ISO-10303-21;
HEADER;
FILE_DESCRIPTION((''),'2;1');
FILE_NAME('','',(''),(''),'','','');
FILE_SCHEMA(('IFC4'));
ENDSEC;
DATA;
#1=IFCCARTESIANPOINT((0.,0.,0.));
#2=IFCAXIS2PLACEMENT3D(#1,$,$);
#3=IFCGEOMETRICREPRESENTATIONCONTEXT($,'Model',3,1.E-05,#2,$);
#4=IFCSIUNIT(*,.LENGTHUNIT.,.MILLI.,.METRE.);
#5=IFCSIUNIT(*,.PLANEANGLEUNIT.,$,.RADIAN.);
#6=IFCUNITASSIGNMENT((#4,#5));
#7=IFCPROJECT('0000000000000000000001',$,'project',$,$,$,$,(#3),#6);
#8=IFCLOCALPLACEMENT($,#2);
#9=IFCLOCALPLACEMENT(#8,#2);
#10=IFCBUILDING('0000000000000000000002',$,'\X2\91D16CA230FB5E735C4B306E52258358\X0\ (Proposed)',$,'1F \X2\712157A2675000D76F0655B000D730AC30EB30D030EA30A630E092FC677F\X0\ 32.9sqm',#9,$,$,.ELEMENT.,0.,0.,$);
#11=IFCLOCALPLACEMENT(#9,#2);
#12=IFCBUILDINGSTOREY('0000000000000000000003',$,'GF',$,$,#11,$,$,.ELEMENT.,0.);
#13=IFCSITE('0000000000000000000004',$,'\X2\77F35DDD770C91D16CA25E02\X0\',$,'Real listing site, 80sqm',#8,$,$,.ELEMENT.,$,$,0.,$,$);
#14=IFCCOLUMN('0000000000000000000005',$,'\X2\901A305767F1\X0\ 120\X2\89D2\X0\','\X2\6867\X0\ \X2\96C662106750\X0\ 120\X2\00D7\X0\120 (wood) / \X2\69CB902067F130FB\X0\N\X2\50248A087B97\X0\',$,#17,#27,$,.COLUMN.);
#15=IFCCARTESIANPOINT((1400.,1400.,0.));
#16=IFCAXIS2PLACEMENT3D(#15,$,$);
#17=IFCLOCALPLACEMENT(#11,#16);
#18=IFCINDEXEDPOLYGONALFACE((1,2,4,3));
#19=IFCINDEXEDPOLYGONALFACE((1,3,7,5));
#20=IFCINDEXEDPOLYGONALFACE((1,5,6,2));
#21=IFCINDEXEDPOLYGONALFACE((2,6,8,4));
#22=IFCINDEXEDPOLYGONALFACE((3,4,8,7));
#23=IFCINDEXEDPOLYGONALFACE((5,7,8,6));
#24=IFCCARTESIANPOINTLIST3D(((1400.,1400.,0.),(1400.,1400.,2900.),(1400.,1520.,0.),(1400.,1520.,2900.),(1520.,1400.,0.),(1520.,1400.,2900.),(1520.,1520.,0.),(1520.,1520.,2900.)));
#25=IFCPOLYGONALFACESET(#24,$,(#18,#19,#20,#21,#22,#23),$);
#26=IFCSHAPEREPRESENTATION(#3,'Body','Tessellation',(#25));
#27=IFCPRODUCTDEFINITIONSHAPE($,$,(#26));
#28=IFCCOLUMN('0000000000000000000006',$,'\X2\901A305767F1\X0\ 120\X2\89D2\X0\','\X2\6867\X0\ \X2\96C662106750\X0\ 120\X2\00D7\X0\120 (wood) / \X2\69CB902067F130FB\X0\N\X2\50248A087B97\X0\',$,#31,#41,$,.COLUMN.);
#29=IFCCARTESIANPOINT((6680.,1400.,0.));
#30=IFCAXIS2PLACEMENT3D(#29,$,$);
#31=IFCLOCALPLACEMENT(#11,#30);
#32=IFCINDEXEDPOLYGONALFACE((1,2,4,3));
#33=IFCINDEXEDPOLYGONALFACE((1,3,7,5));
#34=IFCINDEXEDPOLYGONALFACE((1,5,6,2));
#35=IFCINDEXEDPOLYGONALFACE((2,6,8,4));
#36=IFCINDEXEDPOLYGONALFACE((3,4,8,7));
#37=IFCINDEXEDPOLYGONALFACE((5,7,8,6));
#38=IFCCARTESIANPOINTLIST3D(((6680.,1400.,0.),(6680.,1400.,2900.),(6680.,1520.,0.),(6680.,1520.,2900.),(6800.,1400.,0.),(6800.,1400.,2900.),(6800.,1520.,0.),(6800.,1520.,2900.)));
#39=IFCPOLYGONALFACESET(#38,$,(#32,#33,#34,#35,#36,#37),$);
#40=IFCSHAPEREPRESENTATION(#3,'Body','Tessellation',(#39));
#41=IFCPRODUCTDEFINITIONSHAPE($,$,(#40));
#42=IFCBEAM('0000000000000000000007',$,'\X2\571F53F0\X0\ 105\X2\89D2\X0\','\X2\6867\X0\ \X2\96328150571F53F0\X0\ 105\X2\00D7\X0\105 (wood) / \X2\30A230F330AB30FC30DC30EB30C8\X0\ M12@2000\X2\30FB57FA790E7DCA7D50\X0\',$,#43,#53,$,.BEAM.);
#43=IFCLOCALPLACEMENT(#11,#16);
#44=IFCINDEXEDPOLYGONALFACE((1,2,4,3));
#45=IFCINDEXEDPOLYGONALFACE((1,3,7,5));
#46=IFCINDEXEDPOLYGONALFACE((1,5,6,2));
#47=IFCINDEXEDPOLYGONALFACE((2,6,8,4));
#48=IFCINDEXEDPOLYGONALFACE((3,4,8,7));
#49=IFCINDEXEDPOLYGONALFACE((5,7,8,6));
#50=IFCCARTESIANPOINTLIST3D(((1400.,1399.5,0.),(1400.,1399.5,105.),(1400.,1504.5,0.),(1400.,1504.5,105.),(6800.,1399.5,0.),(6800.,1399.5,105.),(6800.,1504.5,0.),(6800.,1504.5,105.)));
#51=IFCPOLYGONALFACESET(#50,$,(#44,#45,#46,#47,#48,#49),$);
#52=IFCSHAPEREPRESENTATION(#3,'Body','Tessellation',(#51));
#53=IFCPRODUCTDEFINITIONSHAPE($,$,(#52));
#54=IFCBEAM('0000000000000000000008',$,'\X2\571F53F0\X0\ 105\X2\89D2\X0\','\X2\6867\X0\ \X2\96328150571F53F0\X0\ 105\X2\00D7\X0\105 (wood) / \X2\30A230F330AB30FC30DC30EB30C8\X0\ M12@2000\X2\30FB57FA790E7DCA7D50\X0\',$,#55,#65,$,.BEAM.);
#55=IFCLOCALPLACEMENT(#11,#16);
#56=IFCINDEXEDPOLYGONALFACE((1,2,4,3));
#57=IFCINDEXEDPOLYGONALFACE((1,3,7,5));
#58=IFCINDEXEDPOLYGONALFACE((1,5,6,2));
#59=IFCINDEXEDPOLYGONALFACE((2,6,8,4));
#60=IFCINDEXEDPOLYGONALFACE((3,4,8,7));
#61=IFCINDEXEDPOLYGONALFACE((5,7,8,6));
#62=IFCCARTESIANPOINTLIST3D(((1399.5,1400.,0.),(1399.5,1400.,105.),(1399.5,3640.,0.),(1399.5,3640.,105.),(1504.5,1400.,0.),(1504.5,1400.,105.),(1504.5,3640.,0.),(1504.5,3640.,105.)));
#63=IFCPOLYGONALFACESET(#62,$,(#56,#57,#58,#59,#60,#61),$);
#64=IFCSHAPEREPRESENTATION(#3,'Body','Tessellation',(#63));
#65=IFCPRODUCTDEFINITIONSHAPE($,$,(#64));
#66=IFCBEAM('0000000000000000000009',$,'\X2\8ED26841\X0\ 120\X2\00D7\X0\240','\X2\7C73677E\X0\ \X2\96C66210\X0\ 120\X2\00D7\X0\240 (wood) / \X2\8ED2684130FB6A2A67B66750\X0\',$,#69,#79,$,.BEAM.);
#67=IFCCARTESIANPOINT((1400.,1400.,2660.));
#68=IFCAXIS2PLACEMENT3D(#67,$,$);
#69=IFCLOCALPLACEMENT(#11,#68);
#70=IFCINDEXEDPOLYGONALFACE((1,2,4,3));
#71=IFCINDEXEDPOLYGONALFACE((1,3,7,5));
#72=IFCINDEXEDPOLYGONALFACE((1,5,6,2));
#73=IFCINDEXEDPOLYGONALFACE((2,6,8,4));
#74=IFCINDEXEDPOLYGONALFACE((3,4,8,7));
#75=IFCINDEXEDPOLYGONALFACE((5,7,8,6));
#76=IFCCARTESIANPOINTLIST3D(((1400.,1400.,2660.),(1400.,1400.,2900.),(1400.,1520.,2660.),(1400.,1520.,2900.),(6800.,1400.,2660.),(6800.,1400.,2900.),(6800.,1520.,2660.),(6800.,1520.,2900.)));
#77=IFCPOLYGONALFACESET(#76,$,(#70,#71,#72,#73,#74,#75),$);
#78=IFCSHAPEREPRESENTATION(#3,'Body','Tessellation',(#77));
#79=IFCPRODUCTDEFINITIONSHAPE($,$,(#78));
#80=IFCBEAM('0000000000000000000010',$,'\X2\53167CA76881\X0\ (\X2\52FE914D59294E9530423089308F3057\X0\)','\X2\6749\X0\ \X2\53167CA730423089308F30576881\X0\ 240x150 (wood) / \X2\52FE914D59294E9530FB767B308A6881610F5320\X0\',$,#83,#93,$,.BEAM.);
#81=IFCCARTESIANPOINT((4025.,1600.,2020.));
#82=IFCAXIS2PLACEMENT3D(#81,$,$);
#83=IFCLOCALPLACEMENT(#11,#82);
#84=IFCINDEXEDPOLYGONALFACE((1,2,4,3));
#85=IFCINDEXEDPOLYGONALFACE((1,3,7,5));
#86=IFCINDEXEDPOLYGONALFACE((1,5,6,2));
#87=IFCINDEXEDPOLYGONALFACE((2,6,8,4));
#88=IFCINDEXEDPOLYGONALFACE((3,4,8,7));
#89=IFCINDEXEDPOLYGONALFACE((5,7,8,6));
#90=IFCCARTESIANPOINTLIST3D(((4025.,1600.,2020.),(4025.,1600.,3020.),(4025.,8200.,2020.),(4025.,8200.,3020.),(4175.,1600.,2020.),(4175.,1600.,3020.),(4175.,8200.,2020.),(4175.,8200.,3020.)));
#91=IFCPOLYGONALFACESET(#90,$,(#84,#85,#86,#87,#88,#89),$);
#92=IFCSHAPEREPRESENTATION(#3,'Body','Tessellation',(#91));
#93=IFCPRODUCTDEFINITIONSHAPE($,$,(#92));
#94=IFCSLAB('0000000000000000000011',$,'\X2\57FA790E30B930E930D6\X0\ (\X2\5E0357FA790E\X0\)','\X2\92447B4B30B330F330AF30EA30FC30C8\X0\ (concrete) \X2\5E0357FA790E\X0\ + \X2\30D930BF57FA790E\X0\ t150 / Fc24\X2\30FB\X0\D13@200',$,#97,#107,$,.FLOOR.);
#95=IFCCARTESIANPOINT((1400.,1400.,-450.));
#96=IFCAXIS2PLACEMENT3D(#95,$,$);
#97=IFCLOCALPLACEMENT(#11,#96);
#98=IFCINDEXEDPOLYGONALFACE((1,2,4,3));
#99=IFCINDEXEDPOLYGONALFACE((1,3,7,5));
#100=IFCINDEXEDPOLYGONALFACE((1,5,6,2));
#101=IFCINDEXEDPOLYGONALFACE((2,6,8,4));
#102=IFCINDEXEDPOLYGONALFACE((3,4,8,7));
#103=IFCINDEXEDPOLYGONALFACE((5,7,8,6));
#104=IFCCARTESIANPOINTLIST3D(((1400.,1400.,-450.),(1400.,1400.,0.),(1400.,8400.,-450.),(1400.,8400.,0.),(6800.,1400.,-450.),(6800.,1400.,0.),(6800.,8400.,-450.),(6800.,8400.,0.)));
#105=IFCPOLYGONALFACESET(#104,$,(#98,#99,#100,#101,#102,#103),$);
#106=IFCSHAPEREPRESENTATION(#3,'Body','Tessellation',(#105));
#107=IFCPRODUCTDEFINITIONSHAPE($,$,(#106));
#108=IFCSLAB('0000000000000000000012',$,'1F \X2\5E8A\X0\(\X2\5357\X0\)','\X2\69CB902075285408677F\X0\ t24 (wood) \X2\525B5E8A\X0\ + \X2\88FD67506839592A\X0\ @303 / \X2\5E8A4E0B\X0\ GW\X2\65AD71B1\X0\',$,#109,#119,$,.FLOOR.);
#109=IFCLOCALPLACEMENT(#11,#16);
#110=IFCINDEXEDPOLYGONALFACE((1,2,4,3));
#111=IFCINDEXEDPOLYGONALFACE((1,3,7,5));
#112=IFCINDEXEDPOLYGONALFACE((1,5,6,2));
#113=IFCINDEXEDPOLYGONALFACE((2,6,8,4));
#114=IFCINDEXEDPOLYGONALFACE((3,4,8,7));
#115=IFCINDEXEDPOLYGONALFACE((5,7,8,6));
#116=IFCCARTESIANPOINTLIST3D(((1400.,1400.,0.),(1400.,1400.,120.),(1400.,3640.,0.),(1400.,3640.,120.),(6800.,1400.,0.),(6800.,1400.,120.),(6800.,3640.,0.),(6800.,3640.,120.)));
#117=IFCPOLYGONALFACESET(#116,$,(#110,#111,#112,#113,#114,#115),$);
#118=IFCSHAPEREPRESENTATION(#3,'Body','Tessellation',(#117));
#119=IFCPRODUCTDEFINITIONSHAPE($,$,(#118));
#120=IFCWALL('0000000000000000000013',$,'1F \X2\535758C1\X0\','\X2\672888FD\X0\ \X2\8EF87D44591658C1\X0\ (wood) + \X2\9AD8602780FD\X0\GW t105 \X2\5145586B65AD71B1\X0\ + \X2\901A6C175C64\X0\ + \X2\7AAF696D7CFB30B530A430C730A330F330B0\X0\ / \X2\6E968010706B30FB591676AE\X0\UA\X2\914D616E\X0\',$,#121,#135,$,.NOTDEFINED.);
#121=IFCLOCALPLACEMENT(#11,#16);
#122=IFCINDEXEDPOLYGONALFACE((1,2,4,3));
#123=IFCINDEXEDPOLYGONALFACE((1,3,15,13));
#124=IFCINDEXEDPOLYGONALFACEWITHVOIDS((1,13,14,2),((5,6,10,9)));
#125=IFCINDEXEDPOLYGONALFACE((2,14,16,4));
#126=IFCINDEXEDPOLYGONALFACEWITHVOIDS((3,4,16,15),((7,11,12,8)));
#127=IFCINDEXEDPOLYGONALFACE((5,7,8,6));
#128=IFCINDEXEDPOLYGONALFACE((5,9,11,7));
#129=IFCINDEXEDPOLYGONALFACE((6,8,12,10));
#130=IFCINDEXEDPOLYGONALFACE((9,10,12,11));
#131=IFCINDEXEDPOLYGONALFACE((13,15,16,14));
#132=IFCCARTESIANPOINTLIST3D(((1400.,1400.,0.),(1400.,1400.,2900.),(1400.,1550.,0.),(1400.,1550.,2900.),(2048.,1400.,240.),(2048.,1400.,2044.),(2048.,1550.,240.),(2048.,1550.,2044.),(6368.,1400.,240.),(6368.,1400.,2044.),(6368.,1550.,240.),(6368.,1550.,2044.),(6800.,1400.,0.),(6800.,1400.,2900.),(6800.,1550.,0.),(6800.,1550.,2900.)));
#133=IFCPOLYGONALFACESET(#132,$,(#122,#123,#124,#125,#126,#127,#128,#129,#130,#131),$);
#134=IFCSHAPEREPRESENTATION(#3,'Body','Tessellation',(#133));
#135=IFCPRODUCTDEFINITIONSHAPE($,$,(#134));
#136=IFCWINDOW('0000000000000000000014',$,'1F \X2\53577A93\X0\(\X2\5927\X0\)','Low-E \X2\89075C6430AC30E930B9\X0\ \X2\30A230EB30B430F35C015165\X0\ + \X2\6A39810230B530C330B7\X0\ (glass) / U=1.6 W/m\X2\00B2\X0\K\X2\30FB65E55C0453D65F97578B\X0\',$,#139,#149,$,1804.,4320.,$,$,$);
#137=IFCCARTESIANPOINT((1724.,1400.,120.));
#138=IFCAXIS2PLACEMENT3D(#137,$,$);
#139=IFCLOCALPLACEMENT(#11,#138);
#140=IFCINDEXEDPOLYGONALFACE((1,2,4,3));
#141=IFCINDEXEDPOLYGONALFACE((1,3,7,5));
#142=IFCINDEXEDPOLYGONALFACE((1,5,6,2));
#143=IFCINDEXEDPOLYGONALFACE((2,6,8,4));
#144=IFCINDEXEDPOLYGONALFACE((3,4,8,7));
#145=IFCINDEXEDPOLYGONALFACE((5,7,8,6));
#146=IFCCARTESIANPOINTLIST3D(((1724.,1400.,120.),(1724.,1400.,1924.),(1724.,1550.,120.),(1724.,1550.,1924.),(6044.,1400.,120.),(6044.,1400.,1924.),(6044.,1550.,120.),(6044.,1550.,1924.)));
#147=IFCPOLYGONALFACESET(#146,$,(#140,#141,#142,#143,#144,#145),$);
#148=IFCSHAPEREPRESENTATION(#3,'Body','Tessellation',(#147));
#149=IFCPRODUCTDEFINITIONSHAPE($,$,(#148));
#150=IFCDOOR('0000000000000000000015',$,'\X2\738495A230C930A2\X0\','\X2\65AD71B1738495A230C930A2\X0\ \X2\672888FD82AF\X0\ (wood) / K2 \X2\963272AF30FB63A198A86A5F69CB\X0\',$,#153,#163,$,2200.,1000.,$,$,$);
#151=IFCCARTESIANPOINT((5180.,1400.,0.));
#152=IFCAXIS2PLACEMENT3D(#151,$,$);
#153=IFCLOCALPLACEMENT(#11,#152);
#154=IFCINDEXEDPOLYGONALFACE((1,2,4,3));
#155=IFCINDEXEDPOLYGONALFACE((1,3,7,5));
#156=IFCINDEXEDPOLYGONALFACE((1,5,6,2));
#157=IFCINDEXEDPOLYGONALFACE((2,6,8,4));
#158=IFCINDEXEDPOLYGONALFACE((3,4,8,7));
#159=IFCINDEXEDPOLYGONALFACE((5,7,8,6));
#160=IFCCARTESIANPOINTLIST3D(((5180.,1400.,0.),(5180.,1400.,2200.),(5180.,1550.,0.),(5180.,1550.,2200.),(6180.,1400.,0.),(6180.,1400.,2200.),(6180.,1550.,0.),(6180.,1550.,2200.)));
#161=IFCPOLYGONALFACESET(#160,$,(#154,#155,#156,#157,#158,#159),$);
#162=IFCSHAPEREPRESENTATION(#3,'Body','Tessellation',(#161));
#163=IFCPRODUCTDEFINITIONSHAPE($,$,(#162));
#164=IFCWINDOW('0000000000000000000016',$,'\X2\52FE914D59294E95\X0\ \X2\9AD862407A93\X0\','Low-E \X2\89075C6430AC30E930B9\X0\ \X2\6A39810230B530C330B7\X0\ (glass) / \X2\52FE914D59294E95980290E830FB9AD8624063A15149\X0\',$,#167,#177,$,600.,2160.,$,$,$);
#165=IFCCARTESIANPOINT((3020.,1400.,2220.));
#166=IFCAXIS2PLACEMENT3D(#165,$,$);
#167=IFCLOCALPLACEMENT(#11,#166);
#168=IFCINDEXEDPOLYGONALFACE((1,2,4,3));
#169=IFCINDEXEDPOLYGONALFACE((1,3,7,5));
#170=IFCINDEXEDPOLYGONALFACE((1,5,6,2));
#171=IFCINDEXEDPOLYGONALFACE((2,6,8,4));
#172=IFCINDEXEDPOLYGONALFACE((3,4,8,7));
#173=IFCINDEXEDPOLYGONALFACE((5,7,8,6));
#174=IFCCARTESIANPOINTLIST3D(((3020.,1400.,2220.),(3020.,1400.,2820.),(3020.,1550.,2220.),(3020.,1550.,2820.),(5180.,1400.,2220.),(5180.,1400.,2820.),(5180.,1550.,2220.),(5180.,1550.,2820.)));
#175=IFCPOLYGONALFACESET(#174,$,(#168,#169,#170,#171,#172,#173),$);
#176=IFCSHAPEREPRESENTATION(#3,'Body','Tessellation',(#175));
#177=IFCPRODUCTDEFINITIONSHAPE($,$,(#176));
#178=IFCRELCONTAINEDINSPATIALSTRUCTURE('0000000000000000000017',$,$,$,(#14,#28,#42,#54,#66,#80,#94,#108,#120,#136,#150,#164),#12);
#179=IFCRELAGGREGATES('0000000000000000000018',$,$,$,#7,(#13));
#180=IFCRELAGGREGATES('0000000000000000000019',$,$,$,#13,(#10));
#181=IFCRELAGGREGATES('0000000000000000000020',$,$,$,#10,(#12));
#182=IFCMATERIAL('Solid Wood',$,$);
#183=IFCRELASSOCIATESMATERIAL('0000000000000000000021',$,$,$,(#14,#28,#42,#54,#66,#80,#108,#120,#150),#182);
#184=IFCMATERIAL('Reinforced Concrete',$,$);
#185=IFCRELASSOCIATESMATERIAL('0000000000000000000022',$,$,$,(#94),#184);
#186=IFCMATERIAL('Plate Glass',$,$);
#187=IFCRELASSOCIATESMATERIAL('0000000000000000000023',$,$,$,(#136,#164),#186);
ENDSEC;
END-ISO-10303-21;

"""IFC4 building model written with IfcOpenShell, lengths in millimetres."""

from ifc_helpers import new_model, si_unit, frame, frame_2d, origin, place, context, project, spatial, rectangle, extrude, material, element, fill, save


model = new_model("IFC4")

# Units and contexts
model_context = context("Model", 3, precision=1e-05, world=origin())
ifc_project = project(units=[si_unit("LENGTHUNIT", "METRE", prefix="MILLI"), si_unit("PLANEANGLEUNIT", "RADIAN")], contexts=[model_context])

# Site, building, storey
site_placement = place(None, origin())
site = spatial("IfcSite", under=ifc_project, at=site_placement, Name="石川県金沢市", ObjectType="Real listing site, 80sqm", CompositionType="ELEMENT", RefElevation=0.0)
building_placement = place(site_placement, origin())
building = spatial("IfcBuilding", under=site, at=building_placement, Name="金沢・平屋の別荘 (Proposed)", ObjectType="1F 無垢材×漆喰×ガルバリウム鋼板 32.9sqm", CompositionType="ELEMENT", ElevationOfRefHeight=0.0, ElevationOfTerrain=0.0)
storey_placement = place(building_placement, origin())
storey = spatial("IfcBuildingStorey", under=building, at=storey_placement, Name="GF", CompositionType="ELEMENT", Elevation=0.0)

# Columns
ifc_material_1 = material(Name="Solid Wood")
column_1_placement = place(storey_placement, frame((1400.0, 1400.0, 0.0)))
element("IfcColumn", 1, at=column_1_placement, inside=storey, material=ifc_material_1, Name="通し柱 120角", Description="桧 集成材 120×120 (wood) / 構造柱・N値計算", PredefinedType="COLUMN", context=model_context, shape_type="SweptSolid", body=[
    extrude(rectangle(XDim=120.0, YDim=120.0, at=frame_2d((60.0, 60.0))), frame((1400.0, 1400.0, 0.0)), (0.0, 0.0, 1.0), 2900.0),
])
column_2_placement = place(storey_placement, frame((6680.0, 1400.0, 0.0)))
element("IfcColumn", 2, at=column_2_placement, inside=storey, material=ifc_material_1, Name="通し柱 120角", Description="桧 集成材 120×120 (wood) / 構造柱・N値計算", PredefinedType="COLUMN", context=model_context, shape_type="SweptSolid", body=[
    extrude(rectangle(XDim=120.0, YDim=120.0, at=frame_2d((60.0, 60.0))), frame((6680.0, 1400.0, 0.0)), (0.0, 0.0, 1.0), 2900.0),
])

# Beams
beam_1_placement = place(storey_placement, frame((1400.0, 1400.0, 0.0)))
element("IfcBeam", 3, at=beam_1_placement, inside=storey, material=ifc_material_1, Name="土台 105角", Description="桧 防腐土台 105×105 (wood) / アンカーボルト M12@2000・基礎緊結", PredefinedType="BEAM", context=model_context, shape_type="SweptSolid", body=[
    extrude(rectangle(XDim=5400.0, YDim=105.0, at=frame_2d((2700.0, 52.0))), frame((1400.0, 1400.0, 0.0)), (0.0, 0.0, 1.0), 105.0),
])
beam_2_placement = place(storey_placement, frame((1400.0, 1400.0, 0.0)))
element("IfcBeam", 4, at=beam_2_placement, inside=storey, material=ifc_material_1, Name="土台 105角", Description="桧 防腐土台 105×105 (wood) / アンカーボルト M12@2000・基礎緊結", PredefinedType="BEAM", context=model_context, shape_type="SweptSolid", body=[
    extrude(rectangle(XDim=105.0, YDim=2240.0, at=frame_2d((52.0, 1120.0))), frame((1400.0, 1400.0, 0.0)), (0.0, 0.0, 1.0), 105.0),
])
beam_3_placement = place(storey_placement, frame((1400.0, 1400.0, 2660.0)))
element("IfcBeam", 5, at=beam_3_placement, inside=storey, material=ifc_material_1, Name="軒桁 120×240", Description="米松 集成 120×240 (wood) / 軒桁・横架材", PredefinedType="BEAM", context=model_context, shape_type="SweptSolid", body=[
    extrude(rectangle(XDim=5400.0, YDim=120.0, at=frame_2d((2700.0, 60.0))), frame((1400.0, 1400.0, 2660.0)), (0.0, 0.0, 1.0), 240.0),
])
beam_4_placement = place(storey_placement, frame((4025.0, 1600.0, 2020.0)))
element("IfcBeam", 6, at=beam_4_placement, inside=storey, material=ifc_material_1, Name="化粧梁 (勾配天井あらわし)", Description="杉 化粧あらわし梁 240x150 (wood) / 勾配天井・登り梁意匠", PredefinedType="BEAM", context=model_context, shape_type="SweptSolid", body=[
    extrude(rectangle(XDim=150.0, YDim=6600.0, at=frame_2d((75.0, 3300.0))), frame((4025.0, 1600.0, 2020.0)), (0.0, 0.0, 1.0), 1000.0),
])

# Slabs
ifc_material_2 = material(Name="Reinforced Concrete")
slab_1_placement = place(storey_placement, frame((1400.0, 1400.0, -450.0)))
element("IfcSlab", 7, at=slab_1_placement, inside=storey, material=ifc_material_2, Name="基礎スラブ (布基礎)", Description="鉄筋コンクリート (concrete) 布基礎 + ベタ基礎 t150 / Fc24・D13@200", PredefinedType="FLOOR", context=model_context, shape_type="SweptSolid", body=[
    extrude(rectangle(XDim=5400.0, YDim=7000.0, at=frame_2d((2700.0, 3500.0))), frame((1400.0, 1400.0, -450.0)), (0.0, 0.0, 1.0), 450.0),
])
slab_2_placement = place(storey_placement, frame((1400.0, 1400.0, 0.0)))
element("IfcSlab", 8, at=slab_2_placement, inside=storey, material=ifc_material_1, Name="1F 床(南)", Description="構造用合板 t24 (wood) 剛床 + 製材根太 @303 / 床下 GW断熱", PredefinedType="FLOOR", context=model_context, shape_type="SweptSolid", body=[
    extrude(rectangle(XDim=5400.0, YDim=2240.0, at=frame_2d((2700.0, 1120.0))), frame((1400.0, 1400.0, 0.0)), (0.0, 0.0, 1.0), 120.0),
])

# Wall, openings, windows, door
wall_1_placement = place(storey_placement, frame((1400.0, 1400.0, 0.0)))
wall_1 = element("IfcWall", 9, at=wall_1_placement, inside=storey, material=ifc_material_1, Name="1F 南壁", Description="木製 軸組外壁 (wood) + 高性能GW t105 充填断熱 + 通気層 + 窯業系サイディング / 準耐火・外皮UA配慮", PredefinedType="NOTDEFINED", context=model_context, shape_type="SweptSolid", body=[
    extrude(rectangle(XDim=5400.0, YDim=150.0, at=frame_2d((2700.0, 75.0))), frame((1400.0, 1400.0, 0.0)), (0.0, 0.0, 1.0), 2900.0),
])
opening_1_placement = place(storey_placement, frame((1724.0, 1400.0, 120.0)))
opening_1 = element("IfcOpeningElement", 10, at=opening_1_placement, cuts=wall_1, PredefinedType="NOTDEFINED", context=model_context, shape_type="SweptSolid", body=[
    extrude(rectangle(XDim=4320.0, YDim=150.0, at=frame_2d((2160.0, 75.0))), frame((1724.0, 1400.0, 120.0)), (0.0, 0.0, 1.0), 1804.0),
])
opening_2_placement = place(storey_placement, frame((5180.0, 1400.0, 0.0)))
opening_2 = element("IfcOpeningElement", 11, at=opening_2_placement, cuts=wall_1, PredefinedType="NOTDEFINED", context=model_context, shape_type="SweptSolid", body=[
    extrude(rectangle(XDim=1000.0, YDim=150.0, at=frame_2d((500.0, 75.0))), frame((5180.0, 1400.0, 0.0)), (0.0, 0.0, 1.0), 2200.0),
])
opening_3_placement = place(storey_placement, frame((3020.0, 1400.0, 2220.0)))
opening_3 = element("IfcOpeningElement", 12, at=opening_3_placement, cuts=wall_1, PredefinedType="NOTDEFINED", context=model_context, shape_type="SweptSolid", body=[
    extrude(rectangle(XDim=2160.0, YDim=150.0, at=frame_2d((1080.0, 75.0))), frame((3020.0, 1400.0, 2220.0)), (0.0, 0.0, 1.0), 600.0),
])
ifc_material_3 = material(Name="Plate Glass")
window_1_placement = place(storey_placement, frame((1724.0, 1400.0, 120.0)))
window_1 = element("IfcWindow", 13, at=window_1_placement, inside=storey, material=ifc_material_3, Name="1F 南窓(大)", Description="Low-E 複層ガラス アルゴン封入 + 樹脂サッシ (glass) / U=1.6 W/m²K・日射取得型", OverallHeight=1804.0, OverallWidth=4320.0, context=model_context, shape_type="SweptSolid", body=[
    extrude(rectangle(XDim=4320.0, YDim=150.0, at=frame_2d((2160.0, 75.0))), frame((1724.0, 1400.0, 120.0)), (0.0, 0.0, 1.0), 1804.0),
])
fill(opening_1, window_1)
door_placement = place(storey_placement, frame((5180.0, 1400.0, 0.0)))
door = element("IfcDoor", 14, at=door_placement, inside=storey, material=ifc_material_1, Name="玄関ドア", Description="断熱玄関ドア 木製芯 (wood) / K2 防犯・採風機構", OverallHeight=2200.0, OverallWidth=1000.0, context=model_context, shape_type="SweptSolid", body=[
    extrude(rectangle(XDim=1000.0, YDim=150.0, at=frame_2d((500.0, 75.0))), frame((5180.0, 1400.0, 0.0)), (0.0, 0.0, 1.0), 2200.0),
])
fill(opening_2, door)
window_2_placement = place(storey_placement, frame((3020.0, 1400.0, 2220.0)))
window_2 = element("IfcWindow", 15, at=window_2_placement, inside=storey, material=ifc_material_3, Name="勾配天井 高所窓", Description="Low-E 複層ガラス 樹脂サッシ (glass) / 勾配天井頂部・高所採光", OverallHeight=600.0, OverallWidth=2160.0, context=model_context, shape_type="SweptSolid", body=[
    extrude(rectangle(XDim=2160.0, YDim=150.0, at=frame_2d((1080.0, 75.0))), frame((3020.0, 1400.0, 2220.0)), (0.0, 0.0, 1.0), 600.0),
])
fill(opening_3, window_2)

save(model, "model.ifc")
